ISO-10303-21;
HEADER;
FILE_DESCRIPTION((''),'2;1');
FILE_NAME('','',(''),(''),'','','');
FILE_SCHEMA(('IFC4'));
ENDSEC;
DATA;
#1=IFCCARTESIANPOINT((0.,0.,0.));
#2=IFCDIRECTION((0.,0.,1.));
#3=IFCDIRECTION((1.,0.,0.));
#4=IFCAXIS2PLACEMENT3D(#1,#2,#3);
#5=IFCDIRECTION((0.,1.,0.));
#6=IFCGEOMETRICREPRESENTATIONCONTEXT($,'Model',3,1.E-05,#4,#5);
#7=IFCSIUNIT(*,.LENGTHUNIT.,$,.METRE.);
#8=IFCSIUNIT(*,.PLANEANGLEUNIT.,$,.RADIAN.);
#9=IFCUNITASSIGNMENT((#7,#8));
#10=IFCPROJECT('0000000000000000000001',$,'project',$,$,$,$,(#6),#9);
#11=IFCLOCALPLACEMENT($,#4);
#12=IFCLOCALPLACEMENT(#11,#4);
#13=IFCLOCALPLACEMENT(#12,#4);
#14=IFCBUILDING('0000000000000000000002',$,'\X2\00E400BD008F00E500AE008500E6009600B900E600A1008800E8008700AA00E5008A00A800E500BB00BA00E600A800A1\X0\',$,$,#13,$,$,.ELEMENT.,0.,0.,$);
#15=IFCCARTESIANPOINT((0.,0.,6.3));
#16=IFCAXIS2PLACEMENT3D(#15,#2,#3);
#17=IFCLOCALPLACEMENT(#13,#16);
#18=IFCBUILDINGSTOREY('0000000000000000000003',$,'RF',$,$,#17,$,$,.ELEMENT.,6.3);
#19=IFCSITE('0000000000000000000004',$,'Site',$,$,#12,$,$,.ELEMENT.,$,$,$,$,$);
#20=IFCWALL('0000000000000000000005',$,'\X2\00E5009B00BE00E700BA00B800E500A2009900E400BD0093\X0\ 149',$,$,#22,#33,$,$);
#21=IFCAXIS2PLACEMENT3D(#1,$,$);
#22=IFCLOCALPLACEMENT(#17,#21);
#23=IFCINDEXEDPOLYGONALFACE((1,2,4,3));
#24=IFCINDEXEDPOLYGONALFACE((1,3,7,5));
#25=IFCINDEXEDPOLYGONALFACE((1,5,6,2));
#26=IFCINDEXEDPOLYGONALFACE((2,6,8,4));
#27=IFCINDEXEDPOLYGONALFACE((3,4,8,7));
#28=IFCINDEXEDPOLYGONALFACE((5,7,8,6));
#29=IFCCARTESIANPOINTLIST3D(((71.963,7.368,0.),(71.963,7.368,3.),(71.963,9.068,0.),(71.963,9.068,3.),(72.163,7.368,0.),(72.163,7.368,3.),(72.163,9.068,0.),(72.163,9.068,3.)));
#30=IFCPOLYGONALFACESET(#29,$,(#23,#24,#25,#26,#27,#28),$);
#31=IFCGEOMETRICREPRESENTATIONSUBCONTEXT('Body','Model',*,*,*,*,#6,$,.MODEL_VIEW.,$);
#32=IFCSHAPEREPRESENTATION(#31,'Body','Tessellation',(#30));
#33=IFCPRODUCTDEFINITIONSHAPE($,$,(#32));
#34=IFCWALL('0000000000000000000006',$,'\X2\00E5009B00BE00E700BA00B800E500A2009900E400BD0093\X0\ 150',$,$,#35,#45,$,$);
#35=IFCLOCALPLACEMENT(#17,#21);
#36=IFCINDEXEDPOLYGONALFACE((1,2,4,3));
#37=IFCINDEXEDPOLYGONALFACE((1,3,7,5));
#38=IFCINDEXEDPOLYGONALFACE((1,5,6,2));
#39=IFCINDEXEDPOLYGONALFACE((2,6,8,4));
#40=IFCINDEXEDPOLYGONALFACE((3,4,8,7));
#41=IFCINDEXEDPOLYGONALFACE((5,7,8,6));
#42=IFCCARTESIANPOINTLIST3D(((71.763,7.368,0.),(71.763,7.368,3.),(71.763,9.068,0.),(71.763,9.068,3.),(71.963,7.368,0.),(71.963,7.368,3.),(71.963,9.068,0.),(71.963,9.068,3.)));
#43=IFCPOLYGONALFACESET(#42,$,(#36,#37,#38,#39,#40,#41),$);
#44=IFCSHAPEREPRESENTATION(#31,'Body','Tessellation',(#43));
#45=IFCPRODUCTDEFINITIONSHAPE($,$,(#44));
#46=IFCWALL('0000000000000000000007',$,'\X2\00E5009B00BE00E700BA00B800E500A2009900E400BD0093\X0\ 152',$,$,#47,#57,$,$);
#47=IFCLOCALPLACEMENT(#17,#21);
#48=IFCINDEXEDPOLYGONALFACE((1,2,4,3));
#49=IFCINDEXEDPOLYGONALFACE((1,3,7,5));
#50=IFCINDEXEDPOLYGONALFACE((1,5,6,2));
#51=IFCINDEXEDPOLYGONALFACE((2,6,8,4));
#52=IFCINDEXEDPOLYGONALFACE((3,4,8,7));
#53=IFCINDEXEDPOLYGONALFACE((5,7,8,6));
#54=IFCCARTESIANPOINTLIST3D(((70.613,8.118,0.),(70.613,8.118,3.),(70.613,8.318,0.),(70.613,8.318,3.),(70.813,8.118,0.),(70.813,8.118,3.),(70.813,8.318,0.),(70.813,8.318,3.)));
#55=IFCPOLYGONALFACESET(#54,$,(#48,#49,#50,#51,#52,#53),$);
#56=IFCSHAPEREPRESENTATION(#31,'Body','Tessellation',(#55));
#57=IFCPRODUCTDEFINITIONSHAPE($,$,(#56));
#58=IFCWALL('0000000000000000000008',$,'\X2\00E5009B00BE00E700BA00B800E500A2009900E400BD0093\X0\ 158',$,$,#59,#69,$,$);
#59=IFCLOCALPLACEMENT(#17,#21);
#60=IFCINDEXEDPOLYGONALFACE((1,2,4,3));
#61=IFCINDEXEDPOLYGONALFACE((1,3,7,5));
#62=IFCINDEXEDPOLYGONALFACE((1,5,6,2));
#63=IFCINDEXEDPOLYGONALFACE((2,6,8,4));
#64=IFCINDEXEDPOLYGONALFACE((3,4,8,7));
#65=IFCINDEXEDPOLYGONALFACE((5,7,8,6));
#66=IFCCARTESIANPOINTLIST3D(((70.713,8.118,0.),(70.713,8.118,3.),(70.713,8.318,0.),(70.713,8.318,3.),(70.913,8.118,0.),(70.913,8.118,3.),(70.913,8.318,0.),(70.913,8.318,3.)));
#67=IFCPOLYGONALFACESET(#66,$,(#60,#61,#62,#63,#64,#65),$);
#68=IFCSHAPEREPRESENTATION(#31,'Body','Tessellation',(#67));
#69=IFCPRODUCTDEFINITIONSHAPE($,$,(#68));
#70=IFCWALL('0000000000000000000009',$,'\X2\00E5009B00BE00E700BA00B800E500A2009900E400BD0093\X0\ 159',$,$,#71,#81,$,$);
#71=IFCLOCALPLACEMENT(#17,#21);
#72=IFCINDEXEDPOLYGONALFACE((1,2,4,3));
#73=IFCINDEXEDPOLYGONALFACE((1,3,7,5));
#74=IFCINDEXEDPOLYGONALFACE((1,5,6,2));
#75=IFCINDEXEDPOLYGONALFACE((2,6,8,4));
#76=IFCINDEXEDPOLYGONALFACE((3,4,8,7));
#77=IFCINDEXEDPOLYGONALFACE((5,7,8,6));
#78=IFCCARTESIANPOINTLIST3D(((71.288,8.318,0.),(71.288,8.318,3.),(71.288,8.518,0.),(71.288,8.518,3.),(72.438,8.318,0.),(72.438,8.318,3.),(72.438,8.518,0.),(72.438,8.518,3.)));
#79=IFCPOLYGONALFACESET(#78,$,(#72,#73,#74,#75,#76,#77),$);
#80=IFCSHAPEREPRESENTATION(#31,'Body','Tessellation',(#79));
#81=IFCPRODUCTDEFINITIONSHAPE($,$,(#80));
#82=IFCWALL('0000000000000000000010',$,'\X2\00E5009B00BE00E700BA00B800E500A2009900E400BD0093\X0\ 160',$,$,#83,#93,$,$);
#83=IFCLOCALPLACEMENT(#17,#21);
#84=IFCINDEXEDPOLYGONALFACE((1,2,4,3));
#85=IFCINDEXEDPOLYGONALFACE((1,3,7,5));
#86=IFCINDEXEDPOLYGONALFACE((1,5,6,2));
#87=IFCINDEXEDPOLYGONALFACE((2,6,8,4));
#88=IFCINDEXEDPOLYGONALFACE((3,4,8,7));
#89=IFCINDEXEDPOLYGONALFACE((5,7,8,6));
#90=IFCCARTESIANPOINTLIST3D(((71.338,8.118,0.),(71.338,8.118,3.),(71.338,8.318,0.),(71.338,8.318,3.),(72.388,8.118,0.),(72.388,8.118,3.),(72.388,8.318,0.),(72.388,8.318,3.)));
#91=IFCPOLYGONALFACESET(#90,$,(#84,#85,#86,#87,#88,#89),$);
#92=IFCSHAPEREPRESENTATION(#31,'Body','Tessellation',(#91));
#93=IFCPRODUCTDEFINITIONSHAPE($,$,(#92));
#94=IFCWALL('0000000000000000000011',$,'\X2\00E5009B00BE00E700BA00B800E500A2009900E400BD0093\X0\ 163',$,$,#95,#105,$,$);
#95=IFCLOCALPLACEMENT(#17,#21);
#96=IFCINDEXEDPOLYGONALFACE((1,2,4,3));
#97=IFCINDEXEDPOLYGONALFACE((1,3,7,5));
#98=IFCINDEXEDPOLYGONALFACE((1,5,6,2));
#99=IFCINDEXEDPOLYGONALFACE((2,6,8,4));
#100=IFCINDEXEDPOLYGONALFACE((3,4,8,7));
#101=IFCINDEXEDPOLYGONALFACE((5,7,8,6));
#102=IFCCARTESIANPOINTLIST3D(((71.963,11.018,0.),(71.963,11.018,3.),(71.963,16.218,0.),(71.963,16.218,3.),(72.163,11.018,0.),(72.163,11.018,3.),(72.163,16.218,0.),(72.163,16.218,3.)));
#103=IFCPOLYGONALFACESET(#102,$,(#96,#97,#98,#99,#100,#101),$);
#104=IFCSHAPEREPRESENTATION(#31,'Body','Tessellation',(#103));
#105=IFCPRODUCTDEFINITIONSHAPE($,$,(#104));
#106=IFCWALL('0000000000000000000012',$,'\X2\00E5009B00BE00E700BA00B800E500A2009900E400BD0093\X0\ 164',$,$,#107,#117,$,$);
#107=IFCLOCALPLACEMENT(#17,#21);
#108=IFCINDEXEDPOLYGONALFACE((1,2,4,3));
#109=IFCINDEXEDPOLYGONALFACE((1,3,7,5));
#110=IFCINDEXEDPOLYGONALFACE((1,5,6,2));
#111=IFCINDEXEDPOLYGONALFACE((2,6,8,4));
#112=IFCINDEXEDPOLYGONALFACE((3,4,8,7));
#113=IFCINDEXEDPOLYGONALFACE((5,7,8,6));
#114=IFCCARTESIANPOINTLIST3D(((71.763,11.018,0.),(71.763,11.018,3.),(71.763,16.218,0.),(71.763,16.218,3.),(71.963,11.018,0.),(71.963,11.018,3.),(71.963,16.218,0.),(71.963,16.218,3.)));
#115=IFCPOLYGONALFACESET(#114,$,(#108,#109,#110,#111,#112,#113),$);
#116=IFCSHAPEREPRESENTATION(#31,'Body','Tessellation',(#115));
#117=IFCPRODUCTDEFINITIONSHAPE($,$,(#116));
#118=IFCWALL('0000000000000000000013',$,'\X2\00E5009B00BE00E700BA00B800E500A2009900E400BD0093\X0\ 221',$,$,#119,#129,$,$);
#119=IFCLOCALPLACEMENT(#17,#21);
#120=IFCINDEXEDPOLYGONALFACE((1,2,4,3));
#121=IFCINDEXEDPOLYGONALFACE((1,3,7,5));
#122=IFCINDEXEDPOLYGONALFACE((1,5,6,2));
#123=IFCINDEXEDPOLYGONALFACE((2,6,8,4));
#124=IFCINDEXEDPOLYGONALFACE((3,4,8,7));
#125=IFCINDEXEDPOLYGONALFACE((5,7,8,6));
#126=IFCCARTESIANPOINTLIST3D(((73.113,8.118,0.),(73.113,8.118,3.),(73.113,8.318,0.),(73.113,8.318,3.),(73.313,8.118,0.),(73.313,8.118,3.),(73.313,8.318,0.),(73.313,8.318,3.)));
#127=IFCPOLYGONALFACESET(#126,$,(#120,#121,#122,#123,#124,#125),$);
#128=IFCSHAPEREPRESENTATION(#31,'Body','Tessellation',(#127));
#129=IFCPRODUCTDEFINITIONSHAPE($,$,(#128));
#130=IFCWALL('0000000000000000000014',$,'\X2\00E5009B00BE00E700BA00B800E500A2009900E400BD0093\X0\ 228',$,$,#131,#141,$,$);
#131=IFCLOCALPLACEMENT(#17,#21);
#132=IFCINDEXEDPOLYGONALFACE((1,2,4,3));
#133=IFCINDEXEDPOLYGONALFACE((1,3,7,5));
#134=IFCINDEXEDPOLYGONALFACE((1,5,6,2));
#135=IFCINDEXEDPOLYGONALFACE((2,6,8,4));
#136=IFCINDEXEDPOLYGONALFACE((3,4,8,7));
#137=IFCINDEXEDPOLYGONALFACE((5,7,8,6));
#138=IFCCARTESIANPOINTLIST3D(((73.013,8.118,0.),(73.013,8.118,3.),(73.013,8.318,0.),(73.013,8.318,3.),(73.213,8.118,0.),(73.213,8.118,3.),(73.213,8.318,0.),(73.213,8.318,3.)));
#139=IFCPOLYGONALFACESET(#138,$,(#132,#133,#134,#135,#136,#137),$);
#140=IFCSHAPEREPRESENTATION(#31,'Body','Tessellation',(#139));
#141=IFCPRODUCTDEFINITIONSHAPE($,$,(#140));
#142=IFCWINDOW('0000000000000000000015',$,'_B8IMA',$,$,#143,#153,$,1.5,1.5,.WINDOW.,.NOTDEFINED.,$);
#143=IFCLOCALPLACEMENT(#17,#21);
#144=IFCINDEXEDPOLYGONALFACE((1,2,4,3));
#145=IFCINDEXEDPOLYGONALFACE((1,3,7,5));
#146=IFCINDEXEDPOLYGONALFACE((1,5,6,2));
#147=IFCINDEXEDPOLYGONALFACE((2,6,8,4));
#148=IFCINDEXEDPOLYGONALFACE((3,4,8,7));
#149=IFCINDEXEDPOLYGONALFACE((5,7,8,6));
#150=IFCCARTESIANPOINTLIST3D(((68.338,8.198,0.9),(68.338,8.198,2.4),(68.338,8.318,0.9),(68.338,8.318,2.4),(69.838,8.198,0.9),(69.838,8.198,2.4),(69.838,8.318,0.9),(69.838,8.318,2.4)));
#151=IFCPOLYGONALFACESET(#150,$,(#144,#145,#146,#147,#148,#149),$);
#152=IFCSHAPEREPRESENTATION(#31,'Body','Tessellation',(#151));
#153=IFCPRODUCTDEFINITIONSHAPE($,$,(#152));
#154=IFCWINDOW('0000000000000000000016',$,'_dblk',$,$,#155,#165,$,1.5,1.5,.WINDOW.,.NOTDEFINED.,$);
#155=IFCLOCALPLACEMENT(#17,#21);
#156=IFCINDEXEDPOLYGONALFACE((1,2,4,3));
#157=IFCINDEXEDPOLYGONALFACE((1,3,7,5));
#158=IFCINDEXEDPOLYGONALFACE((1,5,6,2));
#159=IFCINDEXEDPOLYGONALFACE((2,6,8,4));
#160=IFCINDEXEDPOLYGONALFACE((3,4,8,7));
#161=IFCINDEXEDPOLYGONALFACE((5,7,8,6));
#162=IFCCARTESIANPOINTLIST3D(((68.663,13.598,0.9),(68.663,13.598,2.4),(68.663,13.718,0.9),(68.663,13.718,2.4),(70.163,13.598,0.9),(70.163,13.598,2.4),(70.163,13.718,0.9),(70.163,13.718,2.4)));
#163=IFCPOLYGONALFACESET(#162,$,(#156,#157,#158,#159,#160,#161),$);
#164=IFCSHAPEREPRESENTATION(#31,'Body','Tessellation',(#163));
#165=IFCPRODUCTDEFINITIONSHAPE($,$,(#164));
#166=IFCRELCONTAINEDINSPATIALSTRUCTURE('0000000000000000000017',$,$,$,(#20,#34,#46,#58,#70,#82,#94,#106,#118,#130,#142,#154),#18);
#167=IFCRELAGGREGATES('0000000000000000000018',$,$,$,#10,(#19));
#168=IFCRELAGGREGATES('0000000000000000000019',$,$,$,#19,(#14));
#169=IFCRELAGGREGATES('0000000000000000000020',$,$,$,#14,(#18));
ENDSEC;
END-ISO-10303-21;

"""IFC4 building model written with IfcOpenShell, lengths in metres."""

from ifc_helpers import new_model, si_unit, direction, frame, frame_2d, origin_with_axes, place, context, subcontext, project, spatial, rectangle, extrude, element, save


model = new_model("IFC4")

# Units and contexts
model_context = context("Model", 3, precision=1e-05, world=origin_with_axes(), true_north=direction((0.0, 1.0, 0.0)))
body_context = subcontext(model_context, "Body", "Model", "MODEL_VIEW")
ifc_project = project(units=[si_unit("LENGTHUNIT", "METRE"), si_unit("PLANEANGLEUNIT", "RADIAN")], contexts=[model_context])

# Site, building, storey
placement = place(None, origin_with_axes())
site_placement = place(placement, origin_with_axes())
site = spatial("IfcSite", under=ifc_project, at=site_placement, Name="Site", CompositionType="ELEMENT")
building_placement = place(site_placement, origin_with_axes())
building = spatial("IfcBuilding", under=site, at=building_placement, Name="ä½\u008få®\u0085æ\u0096¹æ¡\u0088è\u0087ªå\u008a¨å»ºæ¨¡", CompositionType="ELEMENT", ElevationOfRefHeight=0.0, ElevationOfTerrain=0.0)
storey_placement = place(building_placement, frame((0.0, 0.0, 6.3), z_axis=(0.0, 0.0, 1.0), x_axis=(1.0, 0.0, 0.0)))
storey = spatial("IfcBuildingStorey", under=building, at=storey_placement, Name="RF", CompositionType="ELEMENT", Elevation=6.3)

# Walls
for number, where, z_axis, x_axis, name in (
    (1, (72.063, 8.218, 0.0), (0.0, 0.0, 1.0), (0.0, -1.0, 0.0), "å\u009b¾çº¸å¢\u0099ä½\u0093 149"),
    (2, (71.863, 8.218, 0.0), (0.0, 0.0, 1.0), (0.0, -1.0, 0.0), "å\u009b¾çº¸å¢\u0099ä½\u0093 150"),
):
    element("IfcWall", number, at=place(storey_placement, frame(where, z_axis=z_axis, x_axis=x_axis)), inside=storey, Name=name, context=body_context, shape_type="SweptSolid", body=[
        extrude(rectangle(XDim=1.7, YDim=0.2, at=frame_2d((0.0, 0.0), x_axis=(1.0, 0.0, 0.0))), frame((0.0, 0.0, 0.0), z_axis=(0.0, 0.0, 1.0)), (0.0, 0.0, 1.0), 3.0),
    ])
for number, where, z_axis, x_axis, name in (
    (3, (70.713, 8.218, 0.0), (0.0, 0.0, 1.0), (0.0, 1.0, 0.0), "å\u009b¾çº¸å¢\u0099ä½\u0093 152"),
    (4, (70.813, 8.218, 0.0), (0.0, 0.0, 1.0), (0.0, -1.0, 0.0), "å\u009b¾çº¸å¢\u0099ä½\u0093 158"),
):
    element("IfcWall", number, at=place(storey_placement, frame(where, z_axis=z_axis, x_axis=x_axis)), inside=storey, Name=name, context=body_context, shape_type="SweptSolid", body=[
        extrude(rectangle(XDim=0.2, YDim=0.2, at=frame_2d((0.0, 0.0), x_axis=(1.0, 0.0, 0.0))), frame((0.0, 0.0, 0.0), z_axis=(0.0, 0.0, 1.0)), (0.0, 0.0, 1.0), 3.0),
    ])
wall_1_placement = place(storey_placement, frame((71.863, 8.418, 0.0), z_axis=(0.0, 0.0, 1.0), x_axis=(-1.0, 0.0, 0.0)))
element("IfcWall", 5, at=wall_1_placement, inside=storey, Name="å\u009b¾çº¸å¢\u0099ä½\u0093 159", context=body_context, shape_type="SweptSolid", body=[
    extrude(rectangle(XDim=1.15, YDim=0.2, at=frame_2d((0.0, 0.0), x_axis=(1.0, 0.0, 0.0))), frame((0.0, 0.0, 0.0), z_axis=(0.0, 0.0, 1.0)), (0.0, 0.0, 1.0), 3.0),
])
wall_2_placement = place(storey_placement, frame((71.863, 8.218, 0.0), z_axis=(0.0, 0.0, 1.0), x_axis=(-1.0, 0.0, 0.0)))
element("IfcWall", 6, at=wall_2_placement, inside=storey, Name="å\u009b¾çº¸å¢\u0099ä½\u0093 160", context=body_context, shape_type="SweptSolid", body=[
    extrude(rectangle(XDim=1.05, YDim=0.2, at=frame_2d((0.0, 0.0), x_axis=(1.0, 0.0, 0.0))), frame((0.0, 0.0, 0.0), z_axis=(0.0, 0.0, 1.0)), (0.0, 0.0, 1.0), 3.0),
])
for number, where, z_axis, x_axis, name in (
    (7, (72.063, 13.618, 0.0), (0.0, 0.0, 1.0), (0.0, -1.0, 0.0), "å\u009b¾çº¸å¢\u0099ä½\u0093 163"),
    (8, (71.863, 13.618, 0.0), (0.0, 0.0, 1.0), (0.0, -1.0, 0.0), "å\u009b¾çº¸å¢\u0099ä½\u0093 164"),
):
    element("IfcWall", number, at=place(storey_placement, frame(where, z_axis=z_axis, x_axis=x_axis)), inside=storey, Name=name, context=body_context, shape_type="SweptSolid", body=[
        extrude(rectangle(XDim=5.2, YDim=0.2, at=frame_2d((0.0, 0.0), x_axis=(1.0, 0.0, 0.0))), frame((0.0, 0.0, 0.0), z_axis=(0.0, 0.0, 1.0)), (0.0, 0.0, 1.0), 3.0),
    ])
for number, where, z_axis, x_axis, name in (
    (9, (73.213, 8.218, 0.0), (0.0, 0.0, 1.0), (0.0, 1.0, 0.0), "å\u009b¾çº¸å¢\u0099ä½\u0093 221"),
    (10, (73.113, 8.218, 0.0), (0.0, 0.0, 1.0), (0.0, -1.0, 0.0), "å\u009b¾çº¸å¢\u0099ä½\u0093 228"),
):
    element("IfcWall", number, at=place(storey_placement, frame(where, z_axis=z_axis, x_axis=x_axis)), inside=storey, Name=name, context=body_context, shape_type="SweptSolid", body=[
        extrude(rectangle(XDim=0.2, YDim=0.2, at=frame_2d((0.0, 0.0), x_axis=(1.0, 0.0, 0.0))), frame((0.0, 0.0, 0.0), z_axis=(0.0, 0.0, 1.0)), (0.0, 0.0, 1.0), 3.0),
    ])

# Windows
for number, where, z_axis, x_axis, name in (
    (11, (69.088, 8.258, 0.9), (0.0, 0.0, 1.0), (1.0, 0.0, 0.0), "_B8IMA"),
    (12, (69.413, 13.658, 0.9), (0.0, 0.0, 1.0), (1.0, 0.0, 0.0), "_dblk"),
):
    element("IfcWindow", number, at=place(storey_placement, frame(where, z_axis=z_axis, x_axis=x_axis)), inside=storey, Name=name, OverallHeight=1.5, OverallWidth=1.5, PartitioningType="NOTDEFINED", PredefinedType="WINDOW", context=body_context, shape_type="SweptSolid", body=[
        extrude(rectangle(XDim=1.5, YDim=0.12, at=frame_2d((0.0, 0.0), x_axis=(1.0, 0.0, 0.0))), frame((0.0, 0.0, 0.0), z_axis=(0.0, 0.0, 1.0)), (0.0, 0.0, 1.0), 1.5),
    ])

save(model, "model.ifc")
